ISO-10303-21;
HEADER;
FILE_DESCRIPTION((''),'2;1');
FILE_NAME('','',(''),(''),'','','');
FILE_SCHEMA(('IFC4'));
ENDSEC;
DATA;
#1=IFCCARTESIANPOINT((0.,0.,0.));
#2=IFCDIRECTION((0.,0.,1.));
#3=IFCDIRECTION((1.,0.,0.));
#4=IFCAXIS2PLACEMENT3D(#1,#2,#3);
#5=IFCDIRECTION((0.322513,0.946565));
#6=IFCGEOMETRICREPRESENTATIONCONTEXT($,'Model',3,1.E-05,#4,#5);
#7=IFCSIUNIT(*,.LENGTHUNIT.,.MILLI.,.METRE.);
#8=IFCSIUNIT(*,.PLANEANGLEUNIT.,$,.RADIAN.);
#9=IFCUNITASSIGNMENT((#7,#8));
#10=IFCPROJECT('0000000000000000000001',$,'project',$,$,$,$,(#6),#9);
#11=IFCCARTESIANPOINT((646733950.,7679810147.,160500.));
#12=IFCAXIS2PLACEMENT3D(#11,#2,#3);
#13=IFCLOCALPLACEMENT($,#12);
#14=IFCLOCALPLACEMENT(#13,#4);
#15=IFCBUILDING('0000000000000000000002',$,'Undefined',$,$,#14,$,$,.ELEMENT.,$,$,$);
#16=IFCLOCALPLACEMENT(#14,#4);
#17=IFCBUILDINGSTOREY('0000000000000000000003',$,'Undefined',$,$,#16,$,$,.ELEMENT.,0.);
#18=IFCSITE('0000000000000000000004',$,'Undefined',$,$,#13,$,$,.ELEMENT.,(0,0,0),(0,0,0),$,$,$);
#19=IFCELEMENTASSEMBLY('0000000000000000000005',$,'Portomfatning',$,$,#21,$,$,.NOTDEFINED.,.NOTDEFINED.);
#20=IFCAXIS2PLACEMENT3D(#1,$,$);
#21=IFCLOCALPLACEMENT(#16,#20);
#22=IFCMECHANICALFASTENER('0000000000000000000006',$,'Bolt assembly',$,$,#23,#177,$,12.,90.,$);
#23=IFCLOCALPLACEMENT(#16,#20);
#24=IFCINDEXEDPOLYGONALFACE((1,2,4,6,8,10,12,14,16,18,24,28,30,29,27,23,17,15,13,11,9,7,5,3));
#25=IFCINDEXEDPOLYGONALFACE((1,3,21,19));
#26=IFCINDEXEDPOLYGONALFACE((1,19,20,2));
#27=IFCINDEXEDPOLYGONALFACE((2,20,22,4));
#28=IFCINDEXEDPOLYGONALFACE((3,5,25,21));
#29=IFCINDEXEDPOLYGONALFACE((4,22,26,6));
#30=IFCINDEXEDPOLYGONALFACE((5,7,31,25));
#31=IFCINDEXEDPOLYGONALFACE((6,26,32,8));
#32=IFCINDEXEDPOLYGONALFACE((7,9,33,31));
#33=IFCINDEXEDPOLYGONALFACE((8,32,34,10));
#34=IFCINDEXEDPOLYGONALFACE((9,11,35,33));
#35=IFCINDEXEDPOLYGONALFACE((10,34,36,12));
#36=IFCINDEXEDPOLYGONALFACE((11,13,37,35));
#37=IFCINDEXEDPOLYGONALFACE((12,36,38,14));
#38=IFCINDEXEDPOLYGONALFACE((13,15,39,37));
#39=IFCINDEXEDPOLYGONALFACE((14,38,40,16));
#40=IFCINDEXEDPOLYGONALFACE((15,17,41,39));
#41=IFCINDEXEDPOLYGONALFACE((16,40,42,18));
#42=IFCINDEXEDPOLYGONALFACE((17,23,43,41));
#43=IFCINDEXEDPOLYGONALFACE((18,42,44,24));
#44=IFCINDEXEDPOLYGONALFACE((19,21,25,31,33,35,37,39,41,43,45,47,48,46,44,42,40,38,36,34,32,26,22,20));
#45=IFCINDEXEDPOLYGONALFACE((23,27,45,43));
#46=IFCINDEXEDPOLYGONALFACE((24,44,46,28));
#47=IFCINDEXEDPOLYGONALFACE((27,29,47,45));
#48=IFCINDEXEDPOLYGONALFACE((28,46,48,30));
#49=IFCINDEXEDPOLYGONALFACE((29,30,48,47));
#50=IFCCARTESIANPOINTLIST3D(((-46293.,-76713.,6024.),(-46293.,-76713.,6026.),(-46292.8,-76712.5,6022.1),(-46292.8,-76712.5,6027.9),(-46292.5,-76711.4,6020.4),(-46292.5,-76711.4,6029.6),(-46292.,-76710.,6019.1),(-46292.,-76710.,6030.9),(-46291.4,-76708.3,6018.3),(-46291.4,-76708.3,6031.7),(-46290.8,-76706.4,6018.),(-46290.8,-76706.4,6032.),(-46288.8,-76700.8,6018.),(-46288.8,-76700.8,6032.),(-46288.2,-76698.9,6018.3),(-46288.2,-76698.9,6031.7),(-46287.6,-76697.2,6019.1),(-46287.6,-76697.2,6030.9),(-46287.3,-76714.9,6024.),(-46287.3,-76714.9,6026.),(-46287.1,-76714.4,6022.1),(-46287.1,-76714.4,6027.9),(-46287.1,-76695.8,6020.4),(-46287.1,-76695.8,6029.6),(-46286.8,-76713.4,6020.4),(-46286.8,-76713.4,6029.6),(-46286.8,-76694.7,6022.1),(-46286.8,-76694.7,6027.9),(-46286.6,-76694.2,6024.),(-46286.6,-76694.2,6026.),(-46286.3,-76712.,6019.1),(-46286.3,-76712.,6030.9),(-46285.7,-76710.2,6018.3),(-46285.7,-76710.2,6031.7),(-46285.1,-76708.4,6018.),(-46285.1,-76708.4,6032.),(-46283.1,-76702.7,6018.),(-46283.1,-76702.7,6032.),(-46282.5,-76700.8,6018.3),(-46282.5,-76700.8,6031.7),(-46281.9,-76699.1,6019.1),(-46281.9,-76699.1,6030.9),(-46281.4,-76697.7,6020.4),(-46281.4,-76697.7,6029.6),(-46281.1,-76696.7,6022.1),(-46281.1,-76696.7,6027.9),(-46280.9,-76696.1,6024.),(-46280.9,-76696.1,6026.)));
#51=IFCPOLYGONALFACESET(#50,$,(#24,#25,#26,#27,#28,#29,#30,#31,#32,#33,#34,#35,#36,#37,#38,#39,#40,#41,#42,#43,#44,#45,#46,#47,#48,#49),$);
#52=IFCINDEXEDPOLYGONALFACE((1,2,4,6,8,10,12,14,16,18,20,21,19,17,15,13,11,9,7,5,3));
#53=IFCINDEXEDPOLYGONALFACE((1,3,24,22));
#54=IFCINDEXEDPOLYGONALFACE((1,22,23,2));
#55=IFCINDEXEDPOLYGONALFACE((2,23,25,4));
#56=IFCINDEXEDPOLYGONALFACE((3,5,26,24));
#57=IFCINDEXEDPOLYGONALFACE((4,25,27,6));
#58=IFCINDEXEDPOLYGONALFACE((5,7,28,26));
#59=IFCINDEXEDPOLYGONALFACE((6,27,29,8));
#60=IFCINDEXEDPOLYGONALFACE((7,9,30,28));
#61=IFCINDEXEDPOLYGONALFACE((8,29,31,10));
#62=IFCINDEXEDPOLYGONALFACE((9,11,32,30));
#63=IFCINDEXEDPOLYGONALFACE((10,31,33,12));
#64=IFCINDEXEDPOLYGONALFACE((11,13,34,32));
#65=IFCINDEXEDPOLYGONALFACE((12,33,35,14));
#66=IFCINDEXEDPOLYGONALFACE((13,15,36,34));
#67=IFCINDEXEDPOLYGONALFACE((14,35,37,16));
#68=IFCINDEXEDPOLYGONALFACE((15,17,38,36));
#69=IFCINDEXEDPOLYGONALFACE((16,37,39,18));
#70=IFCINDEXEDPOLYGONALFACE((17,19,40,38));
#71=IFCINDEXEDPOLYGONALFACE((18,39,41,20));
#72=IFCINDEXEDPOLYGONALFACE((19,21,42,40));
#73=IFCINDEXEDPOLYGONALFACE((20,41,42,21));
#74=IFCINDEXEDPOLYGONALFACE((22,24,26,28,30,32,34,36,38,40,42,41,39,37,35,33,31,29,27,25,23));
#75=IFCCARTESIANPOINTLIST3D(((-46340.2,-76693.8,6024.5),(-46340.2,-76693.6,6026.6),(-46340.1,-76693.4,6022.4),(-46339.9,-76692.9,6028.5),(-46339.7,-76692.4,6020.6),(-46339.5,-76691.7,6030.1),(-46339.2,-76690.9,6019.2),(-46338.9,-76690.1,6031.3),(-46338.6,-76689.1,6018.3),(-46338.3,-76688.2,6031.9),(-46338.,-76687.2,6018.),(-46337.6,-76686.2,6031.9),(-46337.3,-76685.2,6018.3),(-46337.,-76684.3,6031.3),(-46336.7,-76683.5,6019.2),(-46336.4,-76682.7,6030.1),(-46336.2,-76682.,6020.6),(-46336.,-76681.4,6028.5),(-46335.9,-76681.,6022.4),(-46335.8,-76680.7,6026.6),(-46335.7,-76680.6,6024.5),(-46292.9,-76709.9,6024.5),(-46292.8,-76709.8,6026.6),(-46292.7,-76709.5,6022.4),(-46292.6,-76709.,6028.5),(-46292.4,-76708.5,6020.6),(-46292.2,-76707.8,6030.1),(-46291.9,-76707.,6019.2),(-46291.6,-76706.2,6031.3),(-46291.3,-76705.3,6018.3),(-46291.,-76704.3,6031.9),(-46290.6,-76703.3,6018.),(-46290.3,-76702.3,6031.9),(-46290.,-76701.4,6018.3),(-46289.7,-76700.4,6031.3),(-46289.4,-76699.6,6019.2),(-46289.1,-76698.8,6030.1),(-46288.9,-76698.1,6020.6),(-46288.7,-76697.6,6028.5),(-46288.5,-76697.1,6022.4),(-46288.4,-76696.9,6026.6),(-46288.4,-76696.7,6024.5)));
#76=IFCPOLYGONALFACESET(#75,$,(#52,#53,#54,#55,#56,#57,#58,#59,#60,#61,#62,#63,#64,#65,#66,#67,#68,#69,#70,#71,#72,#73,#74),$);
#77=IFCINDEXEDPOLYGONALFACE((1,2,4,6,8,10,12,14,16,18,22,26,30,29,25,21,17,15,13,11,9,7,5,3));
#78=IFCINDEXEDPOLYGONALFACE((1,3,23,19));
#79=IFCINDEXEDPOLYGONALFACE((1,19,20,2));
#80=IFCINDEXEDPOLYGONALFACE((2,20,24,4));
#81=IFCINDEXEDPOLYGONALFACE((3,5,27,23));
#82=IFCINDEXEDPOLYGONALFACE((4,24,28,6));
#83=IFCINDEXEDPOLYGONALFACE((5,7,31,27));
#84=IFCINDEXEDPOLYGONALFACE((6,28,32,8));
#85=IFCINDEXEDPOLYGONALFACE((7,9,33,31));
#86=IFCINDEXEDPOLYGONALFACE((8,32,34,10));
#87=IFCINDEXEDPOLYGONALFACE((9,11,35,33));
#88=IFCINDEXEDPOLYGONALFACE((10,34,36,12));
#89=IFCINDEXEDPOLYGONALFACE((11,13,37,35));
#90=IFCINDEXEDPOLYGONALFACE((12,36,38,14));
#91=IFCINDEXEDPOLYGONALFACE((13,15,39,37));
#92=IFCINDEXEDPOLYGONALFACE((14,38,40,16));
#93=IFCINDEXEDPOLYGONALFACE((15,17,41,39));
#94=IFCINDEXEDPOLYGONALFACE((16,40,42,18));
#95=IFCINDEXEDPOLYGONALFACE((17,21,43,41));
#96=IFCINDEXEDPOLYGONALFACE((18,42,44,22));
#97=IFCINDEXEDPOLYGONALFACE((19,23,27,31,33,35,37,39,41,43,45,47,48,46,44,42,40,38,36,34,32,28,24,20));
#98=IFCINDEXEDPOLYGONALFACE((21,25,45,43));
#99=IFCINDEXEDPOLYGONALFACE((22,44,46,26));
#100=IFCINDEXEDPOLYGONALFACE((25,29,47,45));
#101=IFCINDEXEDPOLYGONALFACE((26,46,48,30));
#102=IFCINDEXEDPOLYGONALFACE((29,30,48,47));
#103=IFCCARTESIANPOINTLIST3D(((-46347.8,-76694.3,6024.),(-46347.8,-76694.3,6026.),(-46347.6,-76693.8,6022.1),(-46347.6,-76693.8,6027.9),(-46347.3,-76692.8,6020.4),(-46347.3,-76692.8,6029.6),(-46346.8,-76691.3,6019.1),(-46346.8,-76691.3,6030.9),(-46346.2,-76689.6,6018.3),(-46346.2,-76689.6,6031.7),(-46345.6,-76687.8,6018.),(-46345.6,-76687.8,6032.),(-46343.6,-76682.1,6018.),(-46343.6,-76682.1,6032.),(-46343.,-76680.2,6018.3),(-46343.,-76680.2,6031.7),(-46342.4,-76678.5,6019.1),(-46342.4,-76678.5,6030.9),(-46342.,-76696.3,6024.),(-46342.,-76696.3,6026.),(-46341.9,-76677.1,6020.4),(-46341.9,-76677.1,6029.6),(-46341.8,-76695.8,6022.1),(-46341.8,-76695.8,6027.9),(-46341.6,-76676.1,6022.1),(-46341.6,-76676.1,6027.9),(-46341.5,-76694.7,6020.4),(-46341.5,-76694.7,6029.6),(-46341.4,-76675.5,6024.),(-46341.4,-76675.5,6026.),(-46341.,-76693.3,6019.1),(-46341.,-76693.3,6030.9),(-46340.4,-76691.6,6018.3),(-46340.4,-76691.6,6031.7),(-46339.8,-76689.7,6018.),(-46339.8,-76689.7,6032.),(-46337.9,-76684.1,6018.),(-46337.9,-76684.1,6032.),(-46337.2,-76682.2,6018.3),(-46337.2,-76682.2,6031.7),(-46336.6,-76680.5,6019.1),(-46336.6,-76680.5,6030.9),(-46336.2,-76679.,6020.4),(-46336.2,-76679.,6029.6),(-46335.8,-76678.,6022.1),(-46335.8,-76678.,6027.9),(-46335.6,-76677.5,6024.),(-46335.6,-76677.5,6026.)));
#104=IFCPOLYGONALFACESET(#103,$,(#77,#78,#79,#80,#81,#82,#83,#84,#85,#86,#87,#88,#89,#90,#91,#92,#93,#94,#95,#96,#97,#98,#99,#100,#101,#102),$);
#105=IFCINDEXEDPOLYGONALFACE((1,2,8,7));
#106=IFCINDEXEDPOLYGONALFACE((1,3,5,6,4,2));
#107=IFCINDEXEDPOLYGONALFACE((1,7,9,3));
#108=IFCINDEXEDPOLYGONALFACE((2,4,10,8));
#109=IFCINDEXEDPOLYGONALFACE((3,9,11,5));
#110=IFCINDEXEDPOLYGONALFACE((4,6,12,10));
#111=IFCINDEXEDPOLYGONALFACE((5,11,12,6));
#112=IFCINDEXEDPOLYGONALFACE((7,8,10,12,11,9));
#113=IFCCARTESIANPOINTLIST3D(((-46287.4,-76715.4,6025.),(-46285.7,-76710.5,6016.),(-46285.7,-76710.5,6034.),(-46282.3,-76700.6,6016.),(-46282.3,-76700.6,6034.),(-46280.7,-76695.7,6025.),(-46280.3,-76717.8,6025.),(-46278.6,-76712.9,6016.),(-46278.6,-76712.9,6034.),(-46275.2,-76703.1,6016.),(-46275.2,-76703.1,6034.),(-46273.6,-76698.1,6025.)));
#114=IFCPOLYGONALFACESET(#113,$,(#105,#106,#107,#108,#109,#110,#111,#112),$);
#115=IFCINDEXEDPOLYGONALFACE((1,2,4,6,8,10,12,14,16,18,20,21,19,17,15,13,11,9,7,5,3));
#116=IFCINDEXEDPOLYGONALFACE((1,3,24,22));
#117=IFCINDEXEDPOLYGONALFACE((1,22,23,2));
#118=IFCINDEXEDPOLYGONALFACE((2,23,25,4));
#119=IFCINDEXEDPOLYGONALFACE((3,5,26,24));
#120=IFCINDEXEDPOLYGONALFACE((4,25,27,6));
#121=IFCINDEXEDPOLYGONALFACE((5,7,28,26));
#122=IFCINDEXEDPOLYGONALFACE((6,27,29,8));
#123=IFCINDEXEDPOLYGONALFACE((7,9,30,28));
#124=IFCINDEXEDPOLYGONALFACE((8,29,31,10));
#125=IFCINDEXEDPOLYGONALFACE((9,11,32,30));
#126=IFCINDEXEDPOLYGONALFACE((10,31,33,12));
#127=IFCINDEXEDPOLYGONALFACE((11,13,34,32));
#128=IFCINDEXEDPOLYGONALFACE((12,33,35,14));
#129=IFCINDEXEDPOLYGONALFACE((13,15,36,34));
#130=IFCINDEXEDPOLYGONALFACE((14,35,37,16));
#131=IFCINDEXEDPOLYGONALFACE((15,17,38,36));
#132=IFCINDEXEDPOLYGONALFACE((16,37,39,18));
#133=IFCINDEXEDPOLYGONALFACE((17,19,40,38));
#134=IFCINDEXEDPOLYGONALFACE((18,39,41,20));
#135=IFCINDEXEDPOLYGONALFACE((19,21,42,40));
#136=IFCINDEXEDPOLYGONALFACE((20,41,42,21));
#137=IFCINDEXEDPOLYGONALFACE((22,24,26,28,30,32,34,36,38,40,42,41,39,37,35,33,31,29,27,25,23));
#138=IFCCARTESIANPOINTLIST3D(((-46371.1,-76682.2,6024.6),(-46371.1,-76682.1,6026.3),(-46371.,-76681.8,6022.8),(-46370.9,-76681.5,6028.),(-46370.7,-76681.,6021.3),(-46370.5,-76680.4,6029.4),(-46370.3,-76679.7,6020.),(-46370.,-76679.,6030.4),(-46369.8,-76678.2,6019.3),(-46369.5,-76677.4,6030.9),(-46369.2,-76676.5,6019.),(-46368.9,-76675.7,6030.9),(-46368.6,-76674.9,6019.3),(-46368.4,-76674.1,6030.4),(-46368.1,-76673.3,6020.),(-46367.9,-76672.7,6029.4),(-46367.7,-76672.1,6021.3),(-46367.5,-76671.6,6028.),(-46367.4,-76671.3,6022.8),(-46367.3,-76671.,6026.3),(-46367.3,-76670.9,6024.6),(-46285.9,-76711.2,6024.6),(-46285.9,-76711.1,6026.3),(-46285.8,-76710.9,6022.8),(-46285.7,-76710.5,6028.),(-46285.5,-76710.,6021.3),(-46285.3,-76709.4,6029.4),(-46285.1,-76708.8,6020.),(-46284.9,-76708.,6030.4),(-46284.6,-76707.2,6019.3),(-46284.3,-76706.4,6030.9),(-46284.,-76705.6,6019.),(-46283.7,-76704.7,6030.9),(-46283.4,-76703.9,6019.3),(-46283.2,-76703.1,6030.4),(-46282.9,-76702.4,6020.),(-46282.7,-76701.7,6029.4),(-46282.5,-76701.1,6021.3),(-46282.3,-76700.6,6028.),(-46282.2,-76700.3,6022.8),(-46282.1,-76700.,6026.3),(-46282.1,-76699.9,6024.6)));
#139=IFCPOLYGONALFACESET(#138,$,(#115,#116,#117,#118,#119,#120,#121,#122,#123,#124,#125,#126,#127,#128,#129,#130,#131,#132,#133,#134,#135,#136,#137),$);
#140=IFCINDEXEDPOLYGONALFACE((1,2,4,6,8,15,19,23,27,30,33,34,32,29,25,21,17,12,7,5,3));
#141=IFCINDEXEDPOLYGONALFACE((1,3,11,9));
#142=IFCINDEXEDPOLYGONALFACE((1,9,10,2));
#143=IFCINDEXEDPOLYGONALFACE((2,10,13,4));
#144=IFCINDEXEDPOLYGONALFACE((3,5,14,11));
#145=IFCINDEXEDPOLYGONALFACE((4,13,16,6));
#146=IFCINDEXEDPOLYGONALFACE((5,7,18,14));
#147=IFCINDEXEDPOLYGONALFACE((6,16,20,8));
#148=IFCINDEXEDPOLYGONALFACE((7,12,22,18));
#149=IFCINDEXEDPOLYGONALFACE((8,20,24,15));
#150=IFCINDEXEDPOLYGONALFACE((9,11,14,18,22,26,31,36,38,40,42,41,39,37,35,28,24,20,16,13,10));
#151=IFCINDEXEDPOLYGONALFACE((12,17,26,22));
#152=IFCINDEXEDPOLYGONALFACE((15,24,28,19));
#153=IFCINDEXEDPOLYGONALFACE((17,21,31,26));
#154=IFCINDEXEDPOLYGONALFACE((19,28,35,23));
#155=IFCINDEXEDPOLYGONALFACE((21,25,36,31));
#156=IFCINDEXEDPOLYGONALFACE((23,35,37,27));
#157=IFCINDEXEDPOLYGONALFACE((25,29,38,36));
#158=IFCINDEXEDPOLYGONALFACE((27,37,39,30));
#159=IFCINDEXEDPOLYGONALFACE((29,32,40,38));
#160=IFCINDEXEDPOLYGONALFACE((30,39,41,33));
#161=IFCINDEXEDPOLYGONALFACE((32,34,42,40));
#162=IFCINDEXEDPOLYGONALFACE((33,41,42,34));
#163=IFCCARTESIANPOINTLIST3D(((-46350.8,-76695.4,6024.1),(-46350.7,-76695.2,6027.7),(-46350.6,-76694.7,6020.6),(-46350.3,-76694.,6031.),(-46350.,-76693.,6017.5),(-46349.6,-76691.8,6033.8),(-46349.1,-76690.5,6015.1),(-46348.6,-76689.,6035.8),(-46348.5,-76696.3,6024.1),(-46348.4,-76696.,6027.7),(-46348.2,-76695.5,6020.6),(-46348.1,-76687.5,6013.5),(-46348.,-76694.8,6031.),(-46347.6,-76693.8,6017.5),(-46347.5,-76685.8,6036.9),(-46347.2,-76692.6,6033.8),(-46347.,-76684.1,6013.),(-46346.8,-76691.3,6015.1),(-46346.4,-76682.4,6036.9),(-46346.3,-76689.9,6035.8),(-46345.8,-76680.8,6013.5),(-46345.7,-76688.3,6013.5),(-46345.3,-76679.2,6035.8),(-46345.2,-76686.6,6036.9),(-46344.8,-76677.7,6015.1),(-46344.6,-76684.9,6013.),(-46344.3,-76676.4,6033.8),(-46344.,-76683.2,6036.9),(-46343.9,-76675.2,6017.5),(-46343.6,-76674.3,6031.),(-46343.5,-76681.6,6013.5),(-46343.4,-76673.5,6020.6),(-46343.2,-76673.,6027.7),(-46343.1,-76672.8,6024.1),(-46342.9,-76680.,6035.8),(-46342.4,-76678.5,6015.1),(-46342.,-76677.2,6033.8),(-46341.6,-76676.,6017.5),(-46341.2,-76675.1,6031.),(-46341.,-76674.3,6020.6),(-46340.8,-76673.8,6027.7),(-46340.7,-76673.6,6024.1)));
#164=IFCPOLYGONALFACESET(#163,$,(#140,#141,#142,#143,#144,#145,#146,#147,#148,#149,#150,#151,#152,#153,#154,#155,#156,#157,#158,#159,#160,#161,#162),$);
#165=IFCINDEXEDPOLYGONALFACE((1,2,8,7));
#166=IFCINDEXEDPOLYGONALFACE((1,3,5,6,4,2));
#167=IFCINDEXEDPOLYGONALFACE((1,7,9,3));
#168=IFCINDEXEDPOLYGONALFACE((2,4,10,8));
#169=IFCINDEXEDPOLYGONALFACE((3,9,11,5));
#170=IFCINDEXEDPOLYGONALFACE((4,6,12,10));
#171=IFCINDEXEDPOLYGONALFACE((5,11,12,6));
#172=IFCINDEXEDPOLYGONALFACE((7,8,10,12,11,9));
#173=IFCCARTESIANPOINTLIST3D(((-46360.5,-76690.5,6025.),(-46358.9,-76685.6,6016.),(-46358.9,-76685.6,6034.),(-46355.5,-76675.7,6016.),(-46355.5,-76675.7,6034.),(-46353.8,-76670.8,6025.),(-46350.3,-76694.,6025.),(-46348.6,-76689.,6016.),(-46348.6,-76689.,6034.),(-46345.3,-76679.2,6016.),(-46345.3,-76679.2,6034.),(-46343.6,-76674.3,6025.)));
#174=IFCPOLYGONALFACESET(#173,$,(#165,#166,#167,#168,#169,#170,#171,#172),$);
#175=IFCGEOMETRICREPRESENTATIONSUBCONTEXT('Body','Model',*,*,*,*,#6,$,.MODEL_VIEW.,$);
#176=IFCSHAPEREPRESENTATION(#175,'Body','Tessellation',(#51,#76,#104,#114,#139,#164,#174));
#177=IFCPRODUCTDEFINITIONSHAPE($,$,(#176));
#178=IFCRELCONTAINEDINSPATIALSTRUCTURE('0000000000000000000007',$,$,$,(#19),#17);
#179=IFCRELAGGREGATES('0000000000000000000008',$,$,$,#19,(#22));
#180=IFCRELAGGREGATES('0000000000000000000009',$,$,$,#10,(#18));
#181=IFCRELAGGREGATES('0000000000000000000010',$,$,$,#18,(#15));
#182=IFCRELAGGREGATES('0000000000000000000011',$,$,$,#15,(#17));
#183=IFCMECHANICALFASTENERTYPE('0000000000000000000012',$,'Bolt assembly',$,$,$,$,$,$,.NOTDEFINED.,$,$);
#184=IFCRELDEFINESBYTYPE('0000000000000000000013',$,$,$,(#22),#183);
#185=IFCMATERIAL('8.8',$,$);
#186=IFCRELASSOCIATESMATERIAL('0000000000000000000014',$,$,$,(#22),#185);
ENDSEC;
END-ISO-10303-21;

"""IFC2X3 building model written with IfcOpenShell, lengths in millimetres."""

from ifc_helpers import new_model, entity, si_unit, direction, frame, origin_with_axes, origin_2d_with_axis, place, context, subcontext, project, spatial, polyline, circle, outline, extrude, source, transform, mapped, material, type_object, element, aggregate, save


model = new_model("IFC2X3")

# Units and contexts
model_context = context("Model", 3, precision=1e-05, world=origin_with_axes(), true_north=direction((0.322513, 0.946565)))
body_context = subcontext(model_context, "Body", "Model", "MODEL_VIEW")
ifc_project = project(units=[si_unit("LENGTHUNIT", "METRE", prefix="MILLI"), si_unit("PLANEANGLEUNIT", "RADIAN")], contexts=[model_context])

# Site, building, storey
site_placement = place(None, frame((646733950.0, 7679810147.0, 160500.0), z_axis=(0.0, 0.0, 1.0), x_axis=(1.0, 0.0, 0.0)))
site = spatial("IfcSite", under=ifc_project, at=site_placement, Name="Undefined", CompositionType="ELEMENT", RefLatitude=(0, 0, 0), RefLongitude=(0, 0, 0))
building_placement = place(site_placement, origin_with_axes())
building = spatial("IfcBuilding", under=site, at=building_placement, Name="Undefined", CompositionType="ELEMENT")
storey_placement = place(building_placement, origin_with_axes())
storey = spatial("IfcBuildingStorey", under=building, at=storey_placement, Name="Undefined", CompositionType="ELEMENT", Elevation=0.0)

# Shared definitions
ifc_material_1 = material(Name="8.8")
mechanical_fastener_type = type_object("IfcMechanicalFastenerType", Name="Bolt assembly")

# Element assembly, mechanical fastener
assembly_1_placement = place(storey_placement, origin_with_axes())
assembly_1 = element("IfcElementAssembly", 1, at=assembly_1_placement, inside=storey, Name="Portomfatning", AssemblyPlace="NOTDEFINED", PredefinedType="NOTDEFINED")
shared_circle_1 = entity("IfcCircle", entity("IfcAxis2Placement2D", entity("IfcCartesianPoint", [0.0, -3.0]), entity("IfcDirection", [1.0, 0.0])), 7.0)
shared_circle_2 = entity("IfcCircle", entity("IfcAxis2Placement2D", entity("IfcCartesianPoint", [0.0, 3.0]), entity("IfcDirection", [-1.0, 0.0])), 7.0)
shared_composite_curve = entity("IfcCompositeCurve", [entity("IfcCompositeCurveSegment", "CONTINUOUS", True, entity("IfcPolyline", [entity("IfcCartesianPoint", [7.0, 3.0]), entity("IfcCartesianPoint", [7.0, -3.0])])), entity("IfcCompositeCurveSegment", "CONTINUOUS", True, entity("IfcTrimmedCurve", shared_circle_1, [entity("IfcParameterValue", 0.0)], [entity("IfcParameterValue", 3.141593)], False, "PARAMETER")), entity("IfcCompositeCurveSegment", "CONTINUOUS", True, entity("IfcPolyline", [entity("IfcCartesianPoint", [-7.0, -3.0]), entity("IfcCartesianPoint", [-7.0, 3.0])])), entity("IfcCompositeCurveSegment", "DISCONTINUOUS", True, entity("IfcTrimmedCurve", shared_circle_2, [entity("IfcParameterValue", 0.0)], [entity("IfcParameterValue", 3.141593)], False, "PARAMETER"))], False)
shared_shape_1 = source(origin_with_axes(), body_context, "Body", "SweptSolid", [
    entity("IfcExtrudedAreaSolid", entity("IfcArbitraryClosedProfileDef", "AREA", None, shared_composite_curve), entity("IfcAxis2Placement3D", entity("IfcCartesianPoint", [0.0, 5.1, 0.0]), entity("IfcDirection", [0.0, 1.0, 0.0]), entity("IfcDirection", [1.0, 0.0, 0.0])), entity("IfcDirection", [0.0, 0.0, 1.0]), 6.0),
    extrude(circle(Radius=7.0, at=origin_2d_with_axis()), frame((0.0, 12.0, 0.0), z_axis=(0.0, 1.0, 0.0), x_axis=(1.0, 0.0, 0.0)), (0.0, 0.0, 1.0), 50.0),
    entity("IfcExtrudedAreaSolid", entity("IfcArbitraryClosedProfileDef", "AREA", None, shared_composite_curve), entity("IfcAxis2Placement3D", entity("IfcCartesianPoint", [0.0, 62.9, 0.0]), entity("IfcDirection", [0.0, 1.0, 0.0]), entity("IfcDirection", [1.0, 0.0, 0.0])), entity("IfcDirection", [0.0, 0.0, 1.0]), 6.1),
    extrude(outline(polyline([(9.0, -5.2), (9.0, 5.2), (0.0, 10.4), (-9.0, 5.2), (-9.0, -5.2), (0.0, -10.4), (9.0, -5.2)])), frame((0.0, -2.5, 0.0), z_axis=(0.0, 1.0, 0.0), x_axis=(1.0, 0.0, 0.0)), (0.0, 0.0, 1.0), 7.5),
    extrude(circle(Radius=6.0, at=origin_2d_with_axis()), frame((0.0, 5.0, 0.0), z_axis=(0.0, 1.0, 0.0), x_axis=(1.0, 0.0, 0.0)), (0.0, 0.0, 1.0), 90.0),
    extrude(circle(Radius=12.0, at=origin_2d_with_axis()), frame((0.0, 69.0, 0.0), z_axis=(0.0, 1.0, 0.0), x_axis=(1.0, 0.0, 0.0)), (0.0, 0.0, 1.0), 2.5),
    extrude(outline(polyline([(9.0, -5.2), (9.0, 5.2), (0.0, 10.4), (-9.0, 5.2), (-9.0, -5.2), (0.0, -10.4), (9.0, -5.2)])), frame((0.0, 71.5, 0.0), z_axis=(0.0, 1.0, 0.0), x_axis=(1.0, 0.0, 0.0)), (0.0, 0.0, 1.0), 10.8),
])
mechanical_fastener_1_placement = place(assembly_1_placement, frame((-46279.3, -76707.2, 6025.0), z_axis=(0.322513, 0.946565, 0.0), x_axis=(0.0, 0.0, -1.0)))
mechanical_fastener_1 = element("IfcMechanicalFastener", 2, at=mechanical_fastener_1_placement, type_object=mechanical_fastener_type, material=ifc_material_1, Name="Bolt assembly", NominalDiameter=12.0, NominalLength=90.0, context=body_context, shape_type="MappedRepresentation", body=[
    mapped(shared_shape_1, transform((0.0, 0.0, 0.0))),
])
aggregate(assembly_1, [mechanical_fastener_1])

save(model, "model.ifc")
